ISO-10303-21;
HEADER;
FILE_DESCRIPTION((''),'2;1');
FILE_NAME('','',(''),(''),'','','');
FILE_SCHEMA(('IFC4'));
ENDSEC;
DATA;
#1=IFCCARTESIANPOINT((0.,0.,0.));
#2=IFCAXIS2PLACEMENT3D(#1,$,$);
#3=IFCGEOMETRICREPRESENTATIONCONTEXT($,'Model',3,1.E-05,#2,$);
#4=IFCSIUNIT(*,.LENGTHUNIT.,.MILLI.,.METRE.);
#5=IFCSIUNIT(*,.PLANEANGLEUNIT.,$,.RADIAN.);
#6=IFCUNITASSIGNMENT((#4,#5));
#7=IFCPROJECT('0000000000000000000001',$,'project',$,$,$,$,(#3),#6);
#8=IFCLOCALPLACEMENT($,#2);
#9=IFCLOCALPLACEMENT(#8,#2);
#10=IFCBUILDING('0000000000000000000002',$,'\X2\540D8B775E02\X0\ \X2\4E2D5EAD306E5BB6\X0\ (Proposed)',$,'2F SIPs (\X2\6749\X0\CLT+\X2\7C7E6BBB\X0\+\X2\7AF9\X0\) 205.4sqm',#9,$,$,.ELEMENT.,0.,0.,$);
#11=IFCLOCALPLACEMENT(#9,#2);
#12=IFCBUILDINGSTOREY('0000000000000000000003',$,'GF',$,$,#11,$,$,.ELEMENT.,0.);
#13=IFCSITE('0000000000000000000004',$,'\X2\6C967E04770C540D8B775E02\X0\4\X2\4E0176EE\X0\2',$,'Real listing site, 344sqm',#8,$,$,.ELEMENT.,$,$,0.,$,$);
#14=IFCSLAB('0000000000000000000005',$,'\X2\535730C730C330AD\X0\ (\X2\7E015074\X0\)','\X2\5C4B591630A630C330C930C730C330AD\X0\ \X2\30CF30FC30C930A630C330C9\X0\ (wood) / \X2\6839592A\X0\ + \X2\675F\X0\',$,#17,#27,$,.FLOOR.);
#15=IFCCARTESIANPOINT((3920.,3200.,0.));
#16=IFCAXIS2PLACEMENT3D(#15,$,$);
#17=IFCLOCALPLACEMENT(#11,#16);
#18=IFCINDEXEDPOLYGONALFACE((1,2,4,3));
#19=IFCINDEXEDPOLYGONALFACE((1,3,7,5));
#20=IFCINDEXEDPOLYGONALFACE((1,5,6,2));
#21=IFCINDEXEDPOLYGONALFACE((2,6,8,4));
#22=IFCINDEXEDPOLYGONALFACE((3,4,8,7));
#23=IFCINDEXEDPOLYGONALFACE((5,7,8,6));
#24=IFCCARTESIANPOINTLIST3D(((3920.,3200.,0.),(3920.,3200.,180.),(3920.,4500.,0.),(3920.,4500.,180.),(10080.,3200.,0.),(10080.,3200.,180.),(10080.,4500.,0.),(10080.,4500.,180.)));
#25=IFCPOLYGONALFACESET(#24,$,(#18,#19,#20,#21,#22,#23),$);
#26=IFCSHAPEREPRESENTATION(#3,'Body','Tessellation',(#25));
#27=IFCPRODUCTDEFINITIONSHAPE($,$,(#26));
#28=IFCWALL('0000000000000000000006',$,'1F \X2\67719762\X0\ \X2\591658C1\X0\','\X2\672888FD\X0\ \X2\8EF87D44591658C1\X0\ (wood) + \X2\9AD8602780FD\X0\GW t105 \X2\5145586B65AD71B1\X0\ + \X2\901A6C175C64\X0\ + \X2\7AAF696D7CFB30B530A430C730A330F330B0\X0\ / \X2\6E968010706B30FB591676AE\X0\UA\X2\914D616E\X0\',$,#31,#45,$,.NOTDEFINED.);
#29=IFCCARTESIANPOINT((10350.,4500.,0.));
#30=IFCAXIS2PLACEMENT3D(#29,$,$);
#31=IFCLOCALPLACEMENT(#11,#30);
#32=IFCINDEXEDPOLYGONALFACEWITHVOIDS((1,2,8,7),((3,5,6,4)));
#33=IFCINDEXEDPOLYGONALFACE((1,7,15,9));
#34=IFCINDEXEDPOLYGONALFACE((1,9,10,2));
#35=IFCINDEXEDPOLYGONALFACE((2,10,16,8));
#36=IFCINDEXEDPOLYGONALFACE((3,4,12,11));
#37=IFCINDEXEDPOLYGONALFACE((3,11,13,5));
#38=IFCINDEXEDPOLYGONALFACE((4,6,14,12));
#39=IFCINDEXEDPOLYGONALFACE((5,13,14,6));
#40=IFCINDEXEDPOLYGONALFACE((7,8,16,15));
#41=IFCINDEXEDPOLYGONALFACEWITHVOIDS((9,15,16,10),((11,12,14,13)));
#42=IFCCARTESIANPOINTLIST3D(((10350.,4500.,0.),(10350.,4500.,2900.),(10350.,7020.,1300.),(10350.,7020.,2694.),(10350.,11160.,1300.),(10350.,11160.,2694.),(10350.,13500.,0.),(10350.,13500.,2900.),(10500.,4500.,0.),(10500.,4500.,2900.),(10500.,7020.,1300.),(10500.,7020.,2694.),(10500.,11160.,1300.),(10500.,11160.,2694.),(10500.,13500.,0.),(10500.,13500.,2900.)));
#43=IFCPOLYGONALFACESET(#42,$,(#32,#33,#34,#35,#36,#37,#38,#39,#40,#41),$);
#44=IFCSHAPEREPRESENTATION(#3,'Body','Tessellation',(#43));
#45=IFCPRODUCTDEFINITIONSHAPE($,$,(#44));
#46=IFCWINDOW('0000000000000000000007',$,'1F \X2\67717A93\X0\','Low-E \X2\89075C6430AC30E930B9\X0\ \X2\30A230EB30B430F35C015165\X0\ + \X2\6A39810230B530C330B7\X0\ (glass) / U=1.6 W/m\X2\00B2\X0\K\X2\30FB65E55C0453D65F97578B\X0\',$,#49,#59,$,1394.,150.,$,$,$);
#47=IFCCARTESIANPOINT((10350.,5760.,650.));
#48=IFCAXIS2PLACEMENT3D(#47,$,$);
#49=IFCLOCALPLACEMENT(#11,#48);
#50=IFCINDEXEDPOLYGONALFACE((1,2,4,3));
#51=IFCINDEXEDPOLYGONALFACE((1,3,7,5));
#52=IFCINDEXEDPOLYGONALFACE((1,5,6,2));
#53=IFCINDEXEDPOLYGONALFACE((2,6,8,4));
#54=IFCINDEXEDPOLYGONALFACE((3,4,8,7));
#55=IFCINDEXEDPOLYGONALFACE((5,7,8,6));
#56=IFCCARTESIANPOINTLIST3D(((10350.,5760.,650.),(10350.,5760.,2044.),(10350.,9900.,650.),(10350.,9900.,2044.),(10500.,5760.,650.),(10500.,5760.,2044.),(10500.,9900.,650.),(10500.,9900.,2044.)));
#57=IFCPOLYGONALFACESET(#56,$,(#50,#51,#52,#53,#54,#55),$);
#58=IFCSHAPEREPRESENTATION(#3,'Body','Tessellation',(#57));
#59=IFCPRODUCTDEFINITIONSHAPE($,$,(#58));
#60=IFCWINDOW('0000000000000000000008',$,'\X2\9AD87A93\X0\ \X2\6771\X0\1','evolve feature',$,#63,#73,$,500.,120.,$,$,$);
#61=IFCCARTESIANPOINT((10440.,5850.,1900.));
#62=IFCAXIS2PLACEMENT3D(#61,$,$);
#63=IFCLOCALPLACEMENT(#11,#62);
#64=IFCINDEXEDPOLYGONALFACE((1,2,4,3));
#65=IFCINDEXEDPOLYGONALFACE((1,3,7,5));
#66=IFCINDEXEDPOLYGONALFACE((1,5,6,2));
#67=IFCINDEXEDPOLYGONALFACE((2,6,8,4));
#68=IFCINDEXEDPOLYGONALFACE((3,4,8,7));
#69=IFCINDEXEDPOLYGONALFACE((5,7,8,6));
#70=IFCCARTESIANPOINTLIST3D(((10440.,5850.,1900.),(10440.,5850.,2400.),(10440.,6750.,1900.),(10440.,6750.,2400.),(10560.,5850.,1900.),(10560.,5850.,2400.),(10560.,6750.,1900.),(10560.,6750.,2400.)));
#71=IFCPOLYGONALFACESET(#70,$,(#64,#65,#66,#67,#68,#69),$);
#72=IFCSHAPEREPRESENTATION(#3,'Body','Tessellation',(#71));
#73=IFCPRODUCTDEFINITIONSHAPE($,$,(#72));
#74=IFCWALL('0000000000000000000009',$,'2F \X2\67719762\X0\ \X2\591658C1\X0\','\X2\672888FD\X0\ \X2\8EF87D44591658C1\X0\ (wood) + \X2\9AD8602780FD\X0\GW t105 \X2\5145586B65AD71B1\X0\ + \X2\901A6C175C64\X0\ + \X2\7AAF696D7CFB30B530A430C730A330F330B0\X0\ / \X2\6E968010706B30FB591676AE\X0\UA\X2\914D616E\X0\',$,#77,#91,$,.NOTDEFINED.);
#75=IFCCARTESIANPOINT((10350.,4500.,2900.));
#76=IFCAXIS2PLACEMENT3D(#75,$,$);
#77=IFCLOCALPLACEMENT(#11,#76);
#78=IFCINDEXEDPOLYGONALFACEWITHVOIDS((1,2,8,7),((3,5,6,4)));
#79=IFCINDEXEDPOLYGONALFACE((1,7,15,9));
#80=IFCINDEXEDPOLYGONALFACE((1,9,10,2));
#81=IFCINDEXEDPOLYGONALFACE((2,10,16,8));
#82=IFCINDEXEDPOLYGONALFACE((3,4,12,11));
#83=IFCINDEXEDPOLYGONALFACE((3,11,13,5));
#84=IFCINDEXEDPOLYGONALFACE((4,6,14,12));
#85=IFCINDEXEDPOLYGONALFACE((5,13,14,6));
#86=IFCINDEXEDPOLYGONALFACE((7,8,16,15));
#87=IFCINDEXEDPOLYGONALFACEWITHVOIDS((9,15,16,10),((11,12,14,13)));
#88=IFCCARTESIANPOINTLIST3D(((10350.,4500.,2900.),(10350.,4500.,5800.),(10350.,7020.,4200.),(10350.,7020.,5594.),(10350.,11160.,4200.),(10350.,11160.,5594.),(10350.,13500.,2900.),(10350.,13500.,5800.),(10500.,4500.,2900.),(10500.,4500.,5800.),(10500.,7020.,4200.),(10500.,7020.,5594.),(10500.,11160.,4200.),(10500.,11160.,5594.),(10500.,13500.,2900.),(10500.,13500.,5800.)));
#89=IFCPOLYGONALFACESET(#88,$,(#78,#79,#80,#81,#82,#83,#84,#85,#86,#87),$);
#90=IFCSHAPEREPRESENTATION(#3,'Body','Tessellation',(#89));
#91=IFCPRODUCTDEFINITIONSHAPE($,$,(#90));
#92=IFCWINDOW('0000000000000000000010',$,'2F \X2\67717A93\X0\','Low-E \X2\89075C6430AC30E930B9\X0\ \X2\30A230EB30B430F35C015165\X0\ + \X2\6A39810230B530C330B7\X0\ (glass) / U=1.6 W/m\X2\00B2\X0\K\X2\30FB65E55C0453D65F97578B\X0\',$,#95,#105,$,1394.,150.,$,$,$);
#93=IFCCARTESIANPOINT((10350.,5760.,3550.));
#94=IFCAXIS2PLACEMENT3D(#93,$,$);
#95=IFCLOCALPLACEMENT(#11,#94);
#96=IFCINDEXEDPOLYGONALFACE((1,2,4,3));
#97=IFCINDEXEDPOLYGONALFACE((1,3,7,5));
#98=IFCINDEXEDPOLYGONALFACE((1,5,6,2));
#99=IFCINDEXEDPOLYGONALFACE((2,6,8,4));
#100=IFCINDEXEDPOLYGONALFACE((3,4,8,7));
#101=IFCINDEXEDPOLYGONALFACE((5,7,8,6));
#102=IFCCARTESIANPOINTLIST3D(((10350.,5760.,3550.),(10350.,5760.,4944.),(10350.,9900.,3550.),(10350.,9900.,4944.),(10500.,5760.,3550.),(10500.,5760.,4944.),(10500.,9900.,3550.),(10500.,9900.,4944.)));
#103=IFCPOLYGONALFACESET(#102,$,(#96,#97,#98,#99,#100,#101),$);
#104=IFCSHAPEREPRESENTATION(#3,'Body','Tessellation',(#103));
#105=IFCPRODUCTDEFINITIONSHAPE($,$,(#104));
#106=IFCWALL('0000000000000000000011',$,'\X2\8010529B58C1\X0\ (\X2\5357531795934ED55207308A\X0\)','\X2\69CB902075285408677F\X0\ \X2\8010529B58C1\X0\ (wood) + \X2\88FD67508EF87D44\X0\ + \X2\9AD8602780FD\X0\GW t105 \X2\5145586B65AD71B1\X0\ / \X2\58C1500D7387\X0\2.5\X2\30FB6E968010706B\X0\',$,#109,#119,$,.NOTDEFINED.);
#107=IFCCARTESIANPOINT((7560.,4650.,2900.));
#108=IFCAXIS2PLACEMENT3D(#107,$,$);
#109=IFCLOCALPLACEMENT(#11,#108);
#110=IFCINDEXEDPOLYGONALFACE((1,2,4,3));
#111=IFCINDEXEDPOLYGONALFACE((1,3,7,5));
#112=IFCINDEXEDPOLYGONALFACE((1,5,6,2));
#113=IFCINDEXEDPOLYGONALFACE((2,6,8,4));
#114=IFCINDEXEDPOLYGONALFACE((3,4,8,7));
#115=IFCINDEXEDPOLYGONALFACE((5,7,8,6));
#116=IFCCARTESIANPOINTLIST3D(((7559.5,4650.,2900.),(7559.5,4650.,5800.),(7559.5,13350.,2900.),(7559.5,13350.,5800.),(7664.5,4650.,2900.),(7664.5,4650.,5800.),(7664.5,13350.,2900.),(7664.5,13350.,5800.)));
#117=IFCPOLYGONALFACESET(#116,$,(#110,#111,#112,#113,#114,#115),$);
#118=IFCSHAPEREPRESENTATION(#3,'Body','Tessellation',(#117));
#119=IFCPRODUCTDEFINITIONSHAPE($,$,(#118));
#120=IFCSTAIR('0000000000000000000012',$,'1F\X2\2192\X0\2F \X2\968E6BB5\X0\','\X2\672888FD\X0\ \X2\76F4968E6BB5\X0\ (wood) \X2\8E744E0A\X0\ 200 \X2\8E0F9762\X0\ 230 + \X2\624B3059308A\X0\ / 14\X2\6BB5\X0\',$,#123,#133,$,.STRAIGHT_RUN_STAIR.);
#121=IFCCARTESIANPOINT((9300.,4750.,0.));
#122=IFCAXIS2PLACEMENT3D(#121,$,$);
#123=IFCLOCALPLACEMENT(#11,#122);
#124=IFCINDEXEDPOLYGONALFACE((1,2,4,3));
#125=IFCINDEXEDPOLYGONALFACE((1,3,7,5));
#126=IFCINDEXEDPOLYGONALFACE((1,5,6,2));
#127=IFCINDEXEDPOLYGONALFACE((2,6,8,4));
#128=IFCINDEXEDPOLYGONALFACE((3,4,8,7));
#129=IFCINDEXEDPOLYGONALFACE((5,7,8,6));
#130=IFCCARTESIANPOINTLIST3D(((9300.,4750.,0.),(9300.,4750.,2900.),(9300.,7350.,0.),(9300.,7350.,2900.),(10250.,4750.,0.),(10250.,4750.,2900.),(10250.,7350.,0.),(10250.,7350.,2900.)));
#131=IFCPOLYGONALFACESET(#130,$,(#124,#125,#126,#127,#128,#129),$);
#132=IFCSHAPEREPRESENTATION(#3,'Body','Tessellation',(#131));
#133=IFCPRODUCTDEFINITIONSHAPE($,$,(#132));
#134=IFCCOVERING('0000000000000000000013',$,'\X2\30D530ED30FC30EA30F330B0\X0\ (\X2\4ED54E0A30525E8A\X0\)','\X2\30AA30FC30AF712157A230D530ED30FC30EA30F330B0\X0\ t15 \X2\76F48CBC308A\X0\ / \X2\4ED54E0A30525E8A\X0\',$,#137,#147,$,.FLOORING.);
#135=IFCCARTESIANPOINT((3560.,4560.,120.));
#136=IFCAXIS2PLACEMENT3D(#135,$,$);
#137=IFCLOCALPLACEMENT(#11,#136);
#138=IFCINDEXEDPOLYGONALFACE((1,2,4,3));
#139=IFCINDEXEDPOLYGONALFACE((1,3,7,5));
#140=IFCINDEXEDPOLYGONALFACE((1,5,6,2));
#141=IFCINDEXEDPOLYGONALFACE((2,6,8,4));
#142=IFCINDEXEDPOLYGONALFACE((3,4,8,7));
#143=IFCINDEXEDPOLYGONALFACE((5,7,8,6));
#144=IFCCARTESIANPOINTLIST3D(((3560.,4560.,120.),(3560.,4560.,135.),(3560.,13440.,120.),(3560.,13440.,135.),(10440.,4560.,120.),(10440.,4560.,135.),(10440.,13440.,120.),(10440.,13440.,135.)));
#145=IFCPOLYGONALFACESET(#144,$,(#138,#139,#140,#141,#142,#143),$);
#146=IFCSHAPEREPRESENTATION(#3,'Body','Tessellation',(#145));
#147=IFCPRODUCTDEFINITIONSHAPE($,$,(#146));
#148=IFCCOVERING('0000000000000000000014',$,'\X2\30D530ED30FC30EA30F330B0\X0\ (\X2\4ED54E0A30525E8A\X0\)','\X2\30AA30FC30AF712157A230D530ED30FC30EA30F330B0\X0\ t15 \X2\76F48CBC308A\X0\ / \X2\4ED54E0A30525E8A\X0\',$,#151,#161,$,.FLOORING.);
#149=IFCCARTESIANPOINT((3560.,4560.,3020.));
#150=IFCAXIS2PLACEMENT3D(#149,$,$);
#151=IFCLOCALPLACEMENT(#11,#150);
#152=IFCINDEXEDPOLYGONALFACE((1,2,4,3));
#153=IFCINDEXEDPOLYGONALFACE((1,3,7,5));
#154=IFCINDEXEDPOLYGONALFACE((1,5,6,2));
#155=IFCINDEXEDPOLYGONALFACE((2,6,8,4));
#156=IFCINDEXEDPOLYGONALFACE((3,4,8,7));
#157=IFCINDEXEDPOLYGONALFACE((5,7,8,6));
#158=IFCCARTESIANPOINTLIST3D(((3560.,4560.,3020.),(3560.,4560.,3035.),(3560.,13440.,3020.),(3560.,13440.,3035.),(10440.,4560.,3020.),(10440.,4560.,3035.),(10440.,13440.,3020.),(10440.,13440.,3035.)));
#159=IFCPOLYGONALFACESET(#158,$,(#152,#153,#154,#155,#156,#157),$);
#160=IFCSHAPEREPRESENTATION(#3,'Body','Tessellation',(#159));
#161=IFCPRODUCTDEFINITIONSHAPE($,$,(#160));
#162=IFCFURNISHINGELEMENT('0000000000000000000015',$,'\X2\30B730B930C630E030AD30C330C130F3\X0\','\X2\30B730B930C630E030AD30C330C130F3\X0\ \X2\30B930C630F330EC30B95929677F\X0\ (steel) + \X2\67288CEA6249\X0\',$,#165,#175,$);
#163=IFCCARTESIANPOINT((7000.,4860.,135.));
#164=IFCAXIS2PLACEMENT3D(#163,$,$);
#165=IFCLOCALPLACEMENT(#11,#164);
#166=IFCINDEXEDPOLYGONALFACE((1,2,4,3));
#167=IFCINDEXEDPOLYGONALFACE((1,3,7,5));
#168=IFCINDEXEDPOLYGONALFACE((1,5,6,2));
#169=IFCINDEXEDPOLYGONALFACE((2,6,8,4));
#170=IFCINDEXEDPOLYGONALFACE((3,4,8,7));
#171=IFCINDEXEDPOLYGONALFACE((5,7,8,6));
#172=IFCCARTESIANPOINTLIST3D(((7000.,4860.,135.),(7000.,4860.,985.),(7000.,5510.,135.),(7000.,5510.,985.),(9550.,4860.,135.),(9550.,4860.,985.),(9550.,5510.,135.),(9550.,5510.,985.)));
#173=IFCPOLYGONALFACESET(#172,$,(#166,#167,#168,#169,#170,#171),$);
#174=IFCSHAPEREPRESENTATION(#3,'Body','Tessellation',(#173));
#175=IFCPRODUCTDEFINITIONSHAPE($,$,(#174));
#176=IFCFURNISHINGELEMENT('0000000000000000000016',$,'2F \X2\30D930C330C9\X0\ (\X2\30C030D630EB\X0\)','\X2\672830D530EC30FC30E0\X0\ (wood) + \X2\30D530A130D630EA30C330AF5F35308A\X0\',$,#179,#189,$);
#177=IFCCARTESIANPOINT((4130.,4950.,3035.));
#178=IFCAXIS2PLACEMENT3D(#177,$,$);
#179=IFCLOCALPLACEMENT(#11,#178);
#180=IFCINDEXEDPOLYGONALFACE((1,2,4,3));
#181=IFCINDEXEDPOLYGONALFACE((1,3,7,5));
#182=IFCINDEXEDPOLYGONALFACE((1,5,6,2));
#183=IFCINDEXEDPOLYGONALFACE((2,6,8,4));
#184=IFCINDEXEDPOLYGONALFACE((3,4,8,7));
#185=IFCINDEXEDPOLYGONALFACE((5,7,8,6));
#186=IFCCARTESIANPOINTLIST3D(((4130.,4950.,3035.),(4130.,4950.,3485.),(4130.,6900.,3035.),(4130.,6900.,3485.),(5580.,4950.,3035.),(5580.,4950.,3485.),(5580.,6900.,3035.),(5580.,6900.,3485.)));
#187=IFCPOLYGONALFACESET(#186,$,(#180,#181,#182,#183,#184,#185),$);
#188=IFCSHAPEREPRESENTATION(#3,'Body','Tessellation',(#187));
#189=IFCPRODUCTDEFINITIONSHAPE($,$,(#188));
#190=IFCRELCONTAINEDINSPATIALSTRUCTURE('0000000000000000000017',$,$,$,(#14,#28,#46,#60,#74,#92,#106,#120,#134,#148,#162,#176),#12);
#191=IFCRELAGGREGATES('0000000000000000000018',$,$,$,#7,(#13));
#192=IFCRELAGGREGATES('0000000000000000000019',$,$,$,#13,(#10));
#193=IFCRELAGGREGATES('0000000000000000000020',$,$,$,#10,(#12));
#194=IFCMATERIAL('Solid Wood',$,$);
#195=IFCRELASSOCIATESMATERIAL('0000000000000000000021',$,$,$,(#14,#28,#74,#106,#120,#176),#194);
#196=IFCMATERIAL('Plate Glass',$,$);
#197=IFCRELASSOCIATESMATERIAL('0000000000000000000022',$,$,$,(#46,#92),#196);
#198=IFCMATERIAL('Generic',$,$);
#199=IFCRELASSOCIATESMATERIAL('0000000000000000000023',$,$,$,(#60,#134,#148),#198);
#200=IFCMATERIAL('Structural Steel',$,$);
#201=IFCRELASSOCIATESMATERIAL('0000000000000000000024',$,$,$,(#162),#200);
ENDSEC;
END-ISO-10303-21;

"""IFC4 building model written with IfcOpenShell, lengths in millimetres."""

from ifc_helpers import new_model, si_unit, frame, frame_2d, origin, place, context, project, spatial, rectangle, extrude, material, element, fill, save


model = new_model("IFC4")

# Units and contexts
model_context = context("Model", 3, precision=1e-05, world=origin())
ifc_project = project(units=[si_unit("LENGTHUNIT", "METRE", prefix="MILLI"), si_unit("PLANEANGLEUNIT", "RADIAN")], contexts=[model_context])

# Site, building, storey
site_placement = place(None, origin())
site = spatial("IfcSite", under=ifc_project, at=site_placement, Name="沖縄県名護市4丁目2", ObjectType="Real listing site, 344sqm", CompositionType="ELEMENT", RefElevation=0.0)
building_placement = place(site_placement, origin())
building = spatial("IfcBuilding", under=site, at=building_placement, Name="名護市 中庭の家 (Proposed)", ObjectType="2F SIPs (杉CLT+籾殻+竹) 205.4sqm", CompositionType="ELEMENT", ElevationOfRefHeight=0.0, ElevationOfTerrain=0.0)
storey_placement = place(building_placement, origin())
storey = spatial("IfcBuildingStorey", under=building, at=storey_placement, Name="GF", CompositionType="ELEMENT", Elevation=0.0)

# Slab
ifc_material_1 = material(Name="Solid Wood")
slab_placement = place(storey_placement, frame((3920.0, 3200.0, 0.0)))
element("IfcSlab", 1, at=slab_placement, inside=storey, material=ifc_material_1, Name="南デッキ (縁側)", Description="屋外ウッドデッキ ハードウッド (wood) / 根太 + 束", PredefinedType="FLOOR", context=model_context, shape_type="SweptSolid", body=[
    extrude(rectangle(XDim=6160.0, YDim=1300.0, at=frame_2d((3080.0, 650.0))), frame((3920.0, 3200.0, 0.0)), (0.0, 0.0, 1.0), 180.0),
])

# Wall, openings, windows
wall_1_placement = place(storey_placement, frame((10350.0, 4500.0, 0.0)))
wall_1 = element("IfcWall", 2, at=wall_1_placement, inside=storey, material=ifc_material_1, Name="1F 東面 外壁", Description="木製 軸組外壁 (wood) + 高性能GW t105 充填断熱 + 通気層 + 窯業系サイディング / 準耐火・外皮UA配慮", PredefinedType="NOTDEFINED", context=model_context, shape_type="SweptSolid", body=[
    extrude(rectangle(XDim=150.0, YDim=9000.0, at=frame_2d((75.0, 4500.0))), frame((10350.0, 4500.0, 0.0)), (0.0, 0.0, 1.0), 2900.0),
])
opening_1_placement = place(storey_placement, frame((10350.0, 5760.0, 650.0)))
opening_1 = element("IfcOpeningElement", 3, at=opening_1_placement, cuts=wall_1, PredefinedType="NOTDEFINED", context=model_context, shape_type="SweptSolid", body=[
    extrude(rectangle(XDim=150.0, YDim=4140.0, at=frame_2d((75.0, 2070.0))), frame((10350.0, 5760.0, 650.0)), (0.0, 0.0, 1.0), 1394.0),
])
opening_2_placement = place(storey_placement, frame((10440.0, 5850.0, 1900.0)))
opening_2 = element("IfcOpeningElement", 4, at=opening_2_placement, cuts=wall_1, PredefinedType="NOTDEFINED", context=model_context, shape_type="SweptSolid", body=[
    extrude(rectangle(XDim=120.0, YDim=900.0, at=frame_2d((60.0, 450.0))), frame((10440.0, 5850.0, 1900.0)), (0.0, 0.0, 1.0), 500.0),
])
ifc_material_2 = material(Name="Plate Glass")
window_1_placement = place(storey_placement, frame((10350.0, 5760.0, 650.0)))
window_1 = element("IfcWindow", 5, at=window_1_placement, inside=storey, material=ifc_material_2, Name="1F 東窓", Description="Low-E 複層ガラス アルゴン封入 + 樹脂サッシ (glass) / U=1.6 W/m²K・日射取得型", OverallHeight=1394.0, OverallWidth=150.0, context=model_context, shape_type="SweptSolid", body=[
    extrude(rectangle(XDim=150.0, YDim=4140.0, at=frame_2d((75.0, 2070.0))), frame((10350.0, 5760.0, 650.0)), (0.0, 0.0, 1.0), 1394.0),
])
fill(opening_1, window_1)
ifc_material_3 = material(Name="Generic")
window_2_placement = place(storey_placement, frame((10440.0, 5850.0, 1900.0)))
window_2 = element("IfcWindow", 6, at=window_2_placement, inside=storey, material=ifc_material_3, Name="高窓 東1", Description="evolve feature", OverallHeight=500.0, OverallWidth=120.0, context=model_context, shape_type="SweptSolid", body=[
    extrude(rectangle(XDim=120.0, YDim=900.0, at=frame_2d((60.0, 450.0))), frame((10440.0, 5850.0, 1900.0)), (0.0, 0.0, 1.0), 500.0),
])
fill(opening_2, window_2)

# Wall, opening, window
wall_2_placement = place(storey_placement, frame((10350.0, 4500.0, 2900.0)))
wall_2 = element("IfcWall", 7, at=wall_2_placement, inside=storey, material=ifc_material_1, Name="2F 東面 外壁", Description="木製 軸組外壁 (wood) + 高性能GW t105 充填断熱 + 通気層 + 窯業系サイディング / 準耐火・外皮UA配慮", PredefinedType="NOTDEFINED", context=model_context, shape_type="SweptSolid", body=[
    extrude(rectangle(XDim=150.0, YDim=9000.0, at=frame_2d((75.0, 4500.0))), frame((10350.0, 4500.0, 2900.0)), (0.0, 0.0, 1.0), 2900.0),
])
opening_3_placement = place(storey_placement, frame((10350.0, 5760.0, 3550.0)))
opening_3 = element("IfcOpeningElement", 8, at=opening_3_placement, cuts=wall_2, PredefinedType="NOTDEFINED", context=model_context, shape_type="SweptSolid", body=[
    extrude(rectangle(XDim=150.0, YDim=4140.0, at=frame_2d((75.0, 2070.0))), frame((10350.0, 5760.0, 3550.0)), (0.0, 0.0, 1.0), 1394.0),
])
window_3_placement = place(storey_placement, frame((10350.0, 5760.0, 3550.0)))
window_3 = element("IfcWindow", 9, at=window_3_placement, inside=storey, material=ifc_material_2, Name="2F 東窓", Description="Low-E 複層ガラス アルゴン封入 + 樹脂サッシ (glass) / U=1.6 W/m²K・日射取得型", OverallHeight=1394.0, OverallWidth=150.0, context=model_context, shape_type="SweptSolid", body=[
    extrude(rectangle(XDim=150.0, YDim=4140.0, at=frame_2d((75.0, 2070.0))), frame((10350.0, 5760.0, 3550.0)), (0.0, 0.0, 1.0), 1394.0),
])
fill(opening_3, window_3)

# Wall
wall_3_placement = place(storey_placement, frame((7560.0, 4650.0, 2900.0)))
element("IfcWall", 10, at=wall_3_placement, inside=storey, material=ifc_material_1, Name="耐力壁 (南北間仕切り)", Description="構造用合板 耐力壁 (wood) + 製材軸組 + 高性能GW t105 充填断熱 / 壁倍率2.5・準耐火", PredefinedType="NOTDEFINED", context=model_context, shape_type="SweptSolid", body=[
    extrude(rectangle(XDim=105.0, YDim=8700.0, at=frame_2d((52.0, 4350.0))), frame((7560.0, 4650.0, 2900.0)), (0.0, 0.0, 1.0), 2900.0),
])

# Stair
stair_placement = place(storey_placement, frame((9300.0, 4750.0, 0.0)))
element("IfcStair", 11, at=stair_placement, inside=storey, material=ifc_material_1, Name="1F→2F 階段", Description="木製 直階段 (wood) 蹴上 200 踏面 230 + 手すり / 14段", PredefinedType="STRAIGHT_RUN_STAIR", context=model_context, shape_type="SweptSolid", body=[
    extrude(rectangle(XDim=950.0, YDim=2600.0, at=frame_2d((475.0, 1300.0))), frame((9300.0, 4750.0, 0.0)), (0.0, 0.0, 1.0), 2900.0),
])

# Coverings
covering_1_placement = place(storey_placement, frame((3560.0, 4560.0, 120.0)))
element("IfcCovering", 12, at=covering_1_placement, inside=storey, material=ifc_material_3, Name="フローリング (仕上げ床)", Description="オーク無垢フローリング t15 直貼り / 仕上げ床", PredefinedType="FLOORING", context=model_context, shape_type="SweptSolid", body=[
    extrude(rectangle(XDim=6880.0, YDim=8880.0, at=frame_2d((3440.0, 4440.0))), frame((3560.0, 4560.0, 120.0)), (0.0, 0.0, 1.0), 15.0),
])
covering_2_placement = place(storey_placement, frame((3560.0, 4560.0, 3020.0)))
element("IfcCovering", 13, at=covering_2_placement, inside=storey, material=ifc_material_3, Name="フローリング (仕上げ床)", Description="オーク無垢フローリング t15 直貼り / 仕上げ床", PredefinedType="FLOORING", context=model_context, shape_type="SweptSolid", body=[
    extrude(rectangle(XDim=6880.0, YDim=8880.0, at=frame_2d((3440.0, 4440.0))), frame((3560.0, 4560.0, 3020.0)), (0.0, 0.0, 1.0), 15.0),
])

# Furnishing elements
ifc_material_4 = material(Name="Structural Steel")
furnishing_1_placement = place(storey_placement, frame((7000.0, 4860.0, 135.0)))
element("IfcFurnishingElement", 14, at=furnishing_1_placement, inside=storey, material=ifc_material_4, Name="システムキッチン", Description="システムキッチン ステンレス天板 (steel) + 木質扉", context=model_context, shape_type="SweptSolid", body=[
    extrude(rectangle(XDim=2550.0, YDim=650.0, at=frame_2d((1275.0, 325.0))), frame((7000.0, 4860.0, 135.0)), (0.0, 0.0, 1.0), 850.0),
])
furnishing_2_placement = place(storey_placement, frame((4130.0, 4950.0, 3035.0)))
element("IfcFurnishingElement", 15, at=furnishing_2_placement, inside=storey, material=ifc_material_1, Name="2F ベッド (ダブル)", Description="木フレーム (wood) + ファブリック張り", context=model_context, shape_type="SweptSolid", body=[
    extrude(rectangle(XDim=1450.0, YDim=1950.0, at=frame_2d((725.0, 975.0))), frame((4130.0, 4950.0, 3035.0)), (0.0, 0.0, 1.0), 450.0),
])

save(model, "model.ifc")
